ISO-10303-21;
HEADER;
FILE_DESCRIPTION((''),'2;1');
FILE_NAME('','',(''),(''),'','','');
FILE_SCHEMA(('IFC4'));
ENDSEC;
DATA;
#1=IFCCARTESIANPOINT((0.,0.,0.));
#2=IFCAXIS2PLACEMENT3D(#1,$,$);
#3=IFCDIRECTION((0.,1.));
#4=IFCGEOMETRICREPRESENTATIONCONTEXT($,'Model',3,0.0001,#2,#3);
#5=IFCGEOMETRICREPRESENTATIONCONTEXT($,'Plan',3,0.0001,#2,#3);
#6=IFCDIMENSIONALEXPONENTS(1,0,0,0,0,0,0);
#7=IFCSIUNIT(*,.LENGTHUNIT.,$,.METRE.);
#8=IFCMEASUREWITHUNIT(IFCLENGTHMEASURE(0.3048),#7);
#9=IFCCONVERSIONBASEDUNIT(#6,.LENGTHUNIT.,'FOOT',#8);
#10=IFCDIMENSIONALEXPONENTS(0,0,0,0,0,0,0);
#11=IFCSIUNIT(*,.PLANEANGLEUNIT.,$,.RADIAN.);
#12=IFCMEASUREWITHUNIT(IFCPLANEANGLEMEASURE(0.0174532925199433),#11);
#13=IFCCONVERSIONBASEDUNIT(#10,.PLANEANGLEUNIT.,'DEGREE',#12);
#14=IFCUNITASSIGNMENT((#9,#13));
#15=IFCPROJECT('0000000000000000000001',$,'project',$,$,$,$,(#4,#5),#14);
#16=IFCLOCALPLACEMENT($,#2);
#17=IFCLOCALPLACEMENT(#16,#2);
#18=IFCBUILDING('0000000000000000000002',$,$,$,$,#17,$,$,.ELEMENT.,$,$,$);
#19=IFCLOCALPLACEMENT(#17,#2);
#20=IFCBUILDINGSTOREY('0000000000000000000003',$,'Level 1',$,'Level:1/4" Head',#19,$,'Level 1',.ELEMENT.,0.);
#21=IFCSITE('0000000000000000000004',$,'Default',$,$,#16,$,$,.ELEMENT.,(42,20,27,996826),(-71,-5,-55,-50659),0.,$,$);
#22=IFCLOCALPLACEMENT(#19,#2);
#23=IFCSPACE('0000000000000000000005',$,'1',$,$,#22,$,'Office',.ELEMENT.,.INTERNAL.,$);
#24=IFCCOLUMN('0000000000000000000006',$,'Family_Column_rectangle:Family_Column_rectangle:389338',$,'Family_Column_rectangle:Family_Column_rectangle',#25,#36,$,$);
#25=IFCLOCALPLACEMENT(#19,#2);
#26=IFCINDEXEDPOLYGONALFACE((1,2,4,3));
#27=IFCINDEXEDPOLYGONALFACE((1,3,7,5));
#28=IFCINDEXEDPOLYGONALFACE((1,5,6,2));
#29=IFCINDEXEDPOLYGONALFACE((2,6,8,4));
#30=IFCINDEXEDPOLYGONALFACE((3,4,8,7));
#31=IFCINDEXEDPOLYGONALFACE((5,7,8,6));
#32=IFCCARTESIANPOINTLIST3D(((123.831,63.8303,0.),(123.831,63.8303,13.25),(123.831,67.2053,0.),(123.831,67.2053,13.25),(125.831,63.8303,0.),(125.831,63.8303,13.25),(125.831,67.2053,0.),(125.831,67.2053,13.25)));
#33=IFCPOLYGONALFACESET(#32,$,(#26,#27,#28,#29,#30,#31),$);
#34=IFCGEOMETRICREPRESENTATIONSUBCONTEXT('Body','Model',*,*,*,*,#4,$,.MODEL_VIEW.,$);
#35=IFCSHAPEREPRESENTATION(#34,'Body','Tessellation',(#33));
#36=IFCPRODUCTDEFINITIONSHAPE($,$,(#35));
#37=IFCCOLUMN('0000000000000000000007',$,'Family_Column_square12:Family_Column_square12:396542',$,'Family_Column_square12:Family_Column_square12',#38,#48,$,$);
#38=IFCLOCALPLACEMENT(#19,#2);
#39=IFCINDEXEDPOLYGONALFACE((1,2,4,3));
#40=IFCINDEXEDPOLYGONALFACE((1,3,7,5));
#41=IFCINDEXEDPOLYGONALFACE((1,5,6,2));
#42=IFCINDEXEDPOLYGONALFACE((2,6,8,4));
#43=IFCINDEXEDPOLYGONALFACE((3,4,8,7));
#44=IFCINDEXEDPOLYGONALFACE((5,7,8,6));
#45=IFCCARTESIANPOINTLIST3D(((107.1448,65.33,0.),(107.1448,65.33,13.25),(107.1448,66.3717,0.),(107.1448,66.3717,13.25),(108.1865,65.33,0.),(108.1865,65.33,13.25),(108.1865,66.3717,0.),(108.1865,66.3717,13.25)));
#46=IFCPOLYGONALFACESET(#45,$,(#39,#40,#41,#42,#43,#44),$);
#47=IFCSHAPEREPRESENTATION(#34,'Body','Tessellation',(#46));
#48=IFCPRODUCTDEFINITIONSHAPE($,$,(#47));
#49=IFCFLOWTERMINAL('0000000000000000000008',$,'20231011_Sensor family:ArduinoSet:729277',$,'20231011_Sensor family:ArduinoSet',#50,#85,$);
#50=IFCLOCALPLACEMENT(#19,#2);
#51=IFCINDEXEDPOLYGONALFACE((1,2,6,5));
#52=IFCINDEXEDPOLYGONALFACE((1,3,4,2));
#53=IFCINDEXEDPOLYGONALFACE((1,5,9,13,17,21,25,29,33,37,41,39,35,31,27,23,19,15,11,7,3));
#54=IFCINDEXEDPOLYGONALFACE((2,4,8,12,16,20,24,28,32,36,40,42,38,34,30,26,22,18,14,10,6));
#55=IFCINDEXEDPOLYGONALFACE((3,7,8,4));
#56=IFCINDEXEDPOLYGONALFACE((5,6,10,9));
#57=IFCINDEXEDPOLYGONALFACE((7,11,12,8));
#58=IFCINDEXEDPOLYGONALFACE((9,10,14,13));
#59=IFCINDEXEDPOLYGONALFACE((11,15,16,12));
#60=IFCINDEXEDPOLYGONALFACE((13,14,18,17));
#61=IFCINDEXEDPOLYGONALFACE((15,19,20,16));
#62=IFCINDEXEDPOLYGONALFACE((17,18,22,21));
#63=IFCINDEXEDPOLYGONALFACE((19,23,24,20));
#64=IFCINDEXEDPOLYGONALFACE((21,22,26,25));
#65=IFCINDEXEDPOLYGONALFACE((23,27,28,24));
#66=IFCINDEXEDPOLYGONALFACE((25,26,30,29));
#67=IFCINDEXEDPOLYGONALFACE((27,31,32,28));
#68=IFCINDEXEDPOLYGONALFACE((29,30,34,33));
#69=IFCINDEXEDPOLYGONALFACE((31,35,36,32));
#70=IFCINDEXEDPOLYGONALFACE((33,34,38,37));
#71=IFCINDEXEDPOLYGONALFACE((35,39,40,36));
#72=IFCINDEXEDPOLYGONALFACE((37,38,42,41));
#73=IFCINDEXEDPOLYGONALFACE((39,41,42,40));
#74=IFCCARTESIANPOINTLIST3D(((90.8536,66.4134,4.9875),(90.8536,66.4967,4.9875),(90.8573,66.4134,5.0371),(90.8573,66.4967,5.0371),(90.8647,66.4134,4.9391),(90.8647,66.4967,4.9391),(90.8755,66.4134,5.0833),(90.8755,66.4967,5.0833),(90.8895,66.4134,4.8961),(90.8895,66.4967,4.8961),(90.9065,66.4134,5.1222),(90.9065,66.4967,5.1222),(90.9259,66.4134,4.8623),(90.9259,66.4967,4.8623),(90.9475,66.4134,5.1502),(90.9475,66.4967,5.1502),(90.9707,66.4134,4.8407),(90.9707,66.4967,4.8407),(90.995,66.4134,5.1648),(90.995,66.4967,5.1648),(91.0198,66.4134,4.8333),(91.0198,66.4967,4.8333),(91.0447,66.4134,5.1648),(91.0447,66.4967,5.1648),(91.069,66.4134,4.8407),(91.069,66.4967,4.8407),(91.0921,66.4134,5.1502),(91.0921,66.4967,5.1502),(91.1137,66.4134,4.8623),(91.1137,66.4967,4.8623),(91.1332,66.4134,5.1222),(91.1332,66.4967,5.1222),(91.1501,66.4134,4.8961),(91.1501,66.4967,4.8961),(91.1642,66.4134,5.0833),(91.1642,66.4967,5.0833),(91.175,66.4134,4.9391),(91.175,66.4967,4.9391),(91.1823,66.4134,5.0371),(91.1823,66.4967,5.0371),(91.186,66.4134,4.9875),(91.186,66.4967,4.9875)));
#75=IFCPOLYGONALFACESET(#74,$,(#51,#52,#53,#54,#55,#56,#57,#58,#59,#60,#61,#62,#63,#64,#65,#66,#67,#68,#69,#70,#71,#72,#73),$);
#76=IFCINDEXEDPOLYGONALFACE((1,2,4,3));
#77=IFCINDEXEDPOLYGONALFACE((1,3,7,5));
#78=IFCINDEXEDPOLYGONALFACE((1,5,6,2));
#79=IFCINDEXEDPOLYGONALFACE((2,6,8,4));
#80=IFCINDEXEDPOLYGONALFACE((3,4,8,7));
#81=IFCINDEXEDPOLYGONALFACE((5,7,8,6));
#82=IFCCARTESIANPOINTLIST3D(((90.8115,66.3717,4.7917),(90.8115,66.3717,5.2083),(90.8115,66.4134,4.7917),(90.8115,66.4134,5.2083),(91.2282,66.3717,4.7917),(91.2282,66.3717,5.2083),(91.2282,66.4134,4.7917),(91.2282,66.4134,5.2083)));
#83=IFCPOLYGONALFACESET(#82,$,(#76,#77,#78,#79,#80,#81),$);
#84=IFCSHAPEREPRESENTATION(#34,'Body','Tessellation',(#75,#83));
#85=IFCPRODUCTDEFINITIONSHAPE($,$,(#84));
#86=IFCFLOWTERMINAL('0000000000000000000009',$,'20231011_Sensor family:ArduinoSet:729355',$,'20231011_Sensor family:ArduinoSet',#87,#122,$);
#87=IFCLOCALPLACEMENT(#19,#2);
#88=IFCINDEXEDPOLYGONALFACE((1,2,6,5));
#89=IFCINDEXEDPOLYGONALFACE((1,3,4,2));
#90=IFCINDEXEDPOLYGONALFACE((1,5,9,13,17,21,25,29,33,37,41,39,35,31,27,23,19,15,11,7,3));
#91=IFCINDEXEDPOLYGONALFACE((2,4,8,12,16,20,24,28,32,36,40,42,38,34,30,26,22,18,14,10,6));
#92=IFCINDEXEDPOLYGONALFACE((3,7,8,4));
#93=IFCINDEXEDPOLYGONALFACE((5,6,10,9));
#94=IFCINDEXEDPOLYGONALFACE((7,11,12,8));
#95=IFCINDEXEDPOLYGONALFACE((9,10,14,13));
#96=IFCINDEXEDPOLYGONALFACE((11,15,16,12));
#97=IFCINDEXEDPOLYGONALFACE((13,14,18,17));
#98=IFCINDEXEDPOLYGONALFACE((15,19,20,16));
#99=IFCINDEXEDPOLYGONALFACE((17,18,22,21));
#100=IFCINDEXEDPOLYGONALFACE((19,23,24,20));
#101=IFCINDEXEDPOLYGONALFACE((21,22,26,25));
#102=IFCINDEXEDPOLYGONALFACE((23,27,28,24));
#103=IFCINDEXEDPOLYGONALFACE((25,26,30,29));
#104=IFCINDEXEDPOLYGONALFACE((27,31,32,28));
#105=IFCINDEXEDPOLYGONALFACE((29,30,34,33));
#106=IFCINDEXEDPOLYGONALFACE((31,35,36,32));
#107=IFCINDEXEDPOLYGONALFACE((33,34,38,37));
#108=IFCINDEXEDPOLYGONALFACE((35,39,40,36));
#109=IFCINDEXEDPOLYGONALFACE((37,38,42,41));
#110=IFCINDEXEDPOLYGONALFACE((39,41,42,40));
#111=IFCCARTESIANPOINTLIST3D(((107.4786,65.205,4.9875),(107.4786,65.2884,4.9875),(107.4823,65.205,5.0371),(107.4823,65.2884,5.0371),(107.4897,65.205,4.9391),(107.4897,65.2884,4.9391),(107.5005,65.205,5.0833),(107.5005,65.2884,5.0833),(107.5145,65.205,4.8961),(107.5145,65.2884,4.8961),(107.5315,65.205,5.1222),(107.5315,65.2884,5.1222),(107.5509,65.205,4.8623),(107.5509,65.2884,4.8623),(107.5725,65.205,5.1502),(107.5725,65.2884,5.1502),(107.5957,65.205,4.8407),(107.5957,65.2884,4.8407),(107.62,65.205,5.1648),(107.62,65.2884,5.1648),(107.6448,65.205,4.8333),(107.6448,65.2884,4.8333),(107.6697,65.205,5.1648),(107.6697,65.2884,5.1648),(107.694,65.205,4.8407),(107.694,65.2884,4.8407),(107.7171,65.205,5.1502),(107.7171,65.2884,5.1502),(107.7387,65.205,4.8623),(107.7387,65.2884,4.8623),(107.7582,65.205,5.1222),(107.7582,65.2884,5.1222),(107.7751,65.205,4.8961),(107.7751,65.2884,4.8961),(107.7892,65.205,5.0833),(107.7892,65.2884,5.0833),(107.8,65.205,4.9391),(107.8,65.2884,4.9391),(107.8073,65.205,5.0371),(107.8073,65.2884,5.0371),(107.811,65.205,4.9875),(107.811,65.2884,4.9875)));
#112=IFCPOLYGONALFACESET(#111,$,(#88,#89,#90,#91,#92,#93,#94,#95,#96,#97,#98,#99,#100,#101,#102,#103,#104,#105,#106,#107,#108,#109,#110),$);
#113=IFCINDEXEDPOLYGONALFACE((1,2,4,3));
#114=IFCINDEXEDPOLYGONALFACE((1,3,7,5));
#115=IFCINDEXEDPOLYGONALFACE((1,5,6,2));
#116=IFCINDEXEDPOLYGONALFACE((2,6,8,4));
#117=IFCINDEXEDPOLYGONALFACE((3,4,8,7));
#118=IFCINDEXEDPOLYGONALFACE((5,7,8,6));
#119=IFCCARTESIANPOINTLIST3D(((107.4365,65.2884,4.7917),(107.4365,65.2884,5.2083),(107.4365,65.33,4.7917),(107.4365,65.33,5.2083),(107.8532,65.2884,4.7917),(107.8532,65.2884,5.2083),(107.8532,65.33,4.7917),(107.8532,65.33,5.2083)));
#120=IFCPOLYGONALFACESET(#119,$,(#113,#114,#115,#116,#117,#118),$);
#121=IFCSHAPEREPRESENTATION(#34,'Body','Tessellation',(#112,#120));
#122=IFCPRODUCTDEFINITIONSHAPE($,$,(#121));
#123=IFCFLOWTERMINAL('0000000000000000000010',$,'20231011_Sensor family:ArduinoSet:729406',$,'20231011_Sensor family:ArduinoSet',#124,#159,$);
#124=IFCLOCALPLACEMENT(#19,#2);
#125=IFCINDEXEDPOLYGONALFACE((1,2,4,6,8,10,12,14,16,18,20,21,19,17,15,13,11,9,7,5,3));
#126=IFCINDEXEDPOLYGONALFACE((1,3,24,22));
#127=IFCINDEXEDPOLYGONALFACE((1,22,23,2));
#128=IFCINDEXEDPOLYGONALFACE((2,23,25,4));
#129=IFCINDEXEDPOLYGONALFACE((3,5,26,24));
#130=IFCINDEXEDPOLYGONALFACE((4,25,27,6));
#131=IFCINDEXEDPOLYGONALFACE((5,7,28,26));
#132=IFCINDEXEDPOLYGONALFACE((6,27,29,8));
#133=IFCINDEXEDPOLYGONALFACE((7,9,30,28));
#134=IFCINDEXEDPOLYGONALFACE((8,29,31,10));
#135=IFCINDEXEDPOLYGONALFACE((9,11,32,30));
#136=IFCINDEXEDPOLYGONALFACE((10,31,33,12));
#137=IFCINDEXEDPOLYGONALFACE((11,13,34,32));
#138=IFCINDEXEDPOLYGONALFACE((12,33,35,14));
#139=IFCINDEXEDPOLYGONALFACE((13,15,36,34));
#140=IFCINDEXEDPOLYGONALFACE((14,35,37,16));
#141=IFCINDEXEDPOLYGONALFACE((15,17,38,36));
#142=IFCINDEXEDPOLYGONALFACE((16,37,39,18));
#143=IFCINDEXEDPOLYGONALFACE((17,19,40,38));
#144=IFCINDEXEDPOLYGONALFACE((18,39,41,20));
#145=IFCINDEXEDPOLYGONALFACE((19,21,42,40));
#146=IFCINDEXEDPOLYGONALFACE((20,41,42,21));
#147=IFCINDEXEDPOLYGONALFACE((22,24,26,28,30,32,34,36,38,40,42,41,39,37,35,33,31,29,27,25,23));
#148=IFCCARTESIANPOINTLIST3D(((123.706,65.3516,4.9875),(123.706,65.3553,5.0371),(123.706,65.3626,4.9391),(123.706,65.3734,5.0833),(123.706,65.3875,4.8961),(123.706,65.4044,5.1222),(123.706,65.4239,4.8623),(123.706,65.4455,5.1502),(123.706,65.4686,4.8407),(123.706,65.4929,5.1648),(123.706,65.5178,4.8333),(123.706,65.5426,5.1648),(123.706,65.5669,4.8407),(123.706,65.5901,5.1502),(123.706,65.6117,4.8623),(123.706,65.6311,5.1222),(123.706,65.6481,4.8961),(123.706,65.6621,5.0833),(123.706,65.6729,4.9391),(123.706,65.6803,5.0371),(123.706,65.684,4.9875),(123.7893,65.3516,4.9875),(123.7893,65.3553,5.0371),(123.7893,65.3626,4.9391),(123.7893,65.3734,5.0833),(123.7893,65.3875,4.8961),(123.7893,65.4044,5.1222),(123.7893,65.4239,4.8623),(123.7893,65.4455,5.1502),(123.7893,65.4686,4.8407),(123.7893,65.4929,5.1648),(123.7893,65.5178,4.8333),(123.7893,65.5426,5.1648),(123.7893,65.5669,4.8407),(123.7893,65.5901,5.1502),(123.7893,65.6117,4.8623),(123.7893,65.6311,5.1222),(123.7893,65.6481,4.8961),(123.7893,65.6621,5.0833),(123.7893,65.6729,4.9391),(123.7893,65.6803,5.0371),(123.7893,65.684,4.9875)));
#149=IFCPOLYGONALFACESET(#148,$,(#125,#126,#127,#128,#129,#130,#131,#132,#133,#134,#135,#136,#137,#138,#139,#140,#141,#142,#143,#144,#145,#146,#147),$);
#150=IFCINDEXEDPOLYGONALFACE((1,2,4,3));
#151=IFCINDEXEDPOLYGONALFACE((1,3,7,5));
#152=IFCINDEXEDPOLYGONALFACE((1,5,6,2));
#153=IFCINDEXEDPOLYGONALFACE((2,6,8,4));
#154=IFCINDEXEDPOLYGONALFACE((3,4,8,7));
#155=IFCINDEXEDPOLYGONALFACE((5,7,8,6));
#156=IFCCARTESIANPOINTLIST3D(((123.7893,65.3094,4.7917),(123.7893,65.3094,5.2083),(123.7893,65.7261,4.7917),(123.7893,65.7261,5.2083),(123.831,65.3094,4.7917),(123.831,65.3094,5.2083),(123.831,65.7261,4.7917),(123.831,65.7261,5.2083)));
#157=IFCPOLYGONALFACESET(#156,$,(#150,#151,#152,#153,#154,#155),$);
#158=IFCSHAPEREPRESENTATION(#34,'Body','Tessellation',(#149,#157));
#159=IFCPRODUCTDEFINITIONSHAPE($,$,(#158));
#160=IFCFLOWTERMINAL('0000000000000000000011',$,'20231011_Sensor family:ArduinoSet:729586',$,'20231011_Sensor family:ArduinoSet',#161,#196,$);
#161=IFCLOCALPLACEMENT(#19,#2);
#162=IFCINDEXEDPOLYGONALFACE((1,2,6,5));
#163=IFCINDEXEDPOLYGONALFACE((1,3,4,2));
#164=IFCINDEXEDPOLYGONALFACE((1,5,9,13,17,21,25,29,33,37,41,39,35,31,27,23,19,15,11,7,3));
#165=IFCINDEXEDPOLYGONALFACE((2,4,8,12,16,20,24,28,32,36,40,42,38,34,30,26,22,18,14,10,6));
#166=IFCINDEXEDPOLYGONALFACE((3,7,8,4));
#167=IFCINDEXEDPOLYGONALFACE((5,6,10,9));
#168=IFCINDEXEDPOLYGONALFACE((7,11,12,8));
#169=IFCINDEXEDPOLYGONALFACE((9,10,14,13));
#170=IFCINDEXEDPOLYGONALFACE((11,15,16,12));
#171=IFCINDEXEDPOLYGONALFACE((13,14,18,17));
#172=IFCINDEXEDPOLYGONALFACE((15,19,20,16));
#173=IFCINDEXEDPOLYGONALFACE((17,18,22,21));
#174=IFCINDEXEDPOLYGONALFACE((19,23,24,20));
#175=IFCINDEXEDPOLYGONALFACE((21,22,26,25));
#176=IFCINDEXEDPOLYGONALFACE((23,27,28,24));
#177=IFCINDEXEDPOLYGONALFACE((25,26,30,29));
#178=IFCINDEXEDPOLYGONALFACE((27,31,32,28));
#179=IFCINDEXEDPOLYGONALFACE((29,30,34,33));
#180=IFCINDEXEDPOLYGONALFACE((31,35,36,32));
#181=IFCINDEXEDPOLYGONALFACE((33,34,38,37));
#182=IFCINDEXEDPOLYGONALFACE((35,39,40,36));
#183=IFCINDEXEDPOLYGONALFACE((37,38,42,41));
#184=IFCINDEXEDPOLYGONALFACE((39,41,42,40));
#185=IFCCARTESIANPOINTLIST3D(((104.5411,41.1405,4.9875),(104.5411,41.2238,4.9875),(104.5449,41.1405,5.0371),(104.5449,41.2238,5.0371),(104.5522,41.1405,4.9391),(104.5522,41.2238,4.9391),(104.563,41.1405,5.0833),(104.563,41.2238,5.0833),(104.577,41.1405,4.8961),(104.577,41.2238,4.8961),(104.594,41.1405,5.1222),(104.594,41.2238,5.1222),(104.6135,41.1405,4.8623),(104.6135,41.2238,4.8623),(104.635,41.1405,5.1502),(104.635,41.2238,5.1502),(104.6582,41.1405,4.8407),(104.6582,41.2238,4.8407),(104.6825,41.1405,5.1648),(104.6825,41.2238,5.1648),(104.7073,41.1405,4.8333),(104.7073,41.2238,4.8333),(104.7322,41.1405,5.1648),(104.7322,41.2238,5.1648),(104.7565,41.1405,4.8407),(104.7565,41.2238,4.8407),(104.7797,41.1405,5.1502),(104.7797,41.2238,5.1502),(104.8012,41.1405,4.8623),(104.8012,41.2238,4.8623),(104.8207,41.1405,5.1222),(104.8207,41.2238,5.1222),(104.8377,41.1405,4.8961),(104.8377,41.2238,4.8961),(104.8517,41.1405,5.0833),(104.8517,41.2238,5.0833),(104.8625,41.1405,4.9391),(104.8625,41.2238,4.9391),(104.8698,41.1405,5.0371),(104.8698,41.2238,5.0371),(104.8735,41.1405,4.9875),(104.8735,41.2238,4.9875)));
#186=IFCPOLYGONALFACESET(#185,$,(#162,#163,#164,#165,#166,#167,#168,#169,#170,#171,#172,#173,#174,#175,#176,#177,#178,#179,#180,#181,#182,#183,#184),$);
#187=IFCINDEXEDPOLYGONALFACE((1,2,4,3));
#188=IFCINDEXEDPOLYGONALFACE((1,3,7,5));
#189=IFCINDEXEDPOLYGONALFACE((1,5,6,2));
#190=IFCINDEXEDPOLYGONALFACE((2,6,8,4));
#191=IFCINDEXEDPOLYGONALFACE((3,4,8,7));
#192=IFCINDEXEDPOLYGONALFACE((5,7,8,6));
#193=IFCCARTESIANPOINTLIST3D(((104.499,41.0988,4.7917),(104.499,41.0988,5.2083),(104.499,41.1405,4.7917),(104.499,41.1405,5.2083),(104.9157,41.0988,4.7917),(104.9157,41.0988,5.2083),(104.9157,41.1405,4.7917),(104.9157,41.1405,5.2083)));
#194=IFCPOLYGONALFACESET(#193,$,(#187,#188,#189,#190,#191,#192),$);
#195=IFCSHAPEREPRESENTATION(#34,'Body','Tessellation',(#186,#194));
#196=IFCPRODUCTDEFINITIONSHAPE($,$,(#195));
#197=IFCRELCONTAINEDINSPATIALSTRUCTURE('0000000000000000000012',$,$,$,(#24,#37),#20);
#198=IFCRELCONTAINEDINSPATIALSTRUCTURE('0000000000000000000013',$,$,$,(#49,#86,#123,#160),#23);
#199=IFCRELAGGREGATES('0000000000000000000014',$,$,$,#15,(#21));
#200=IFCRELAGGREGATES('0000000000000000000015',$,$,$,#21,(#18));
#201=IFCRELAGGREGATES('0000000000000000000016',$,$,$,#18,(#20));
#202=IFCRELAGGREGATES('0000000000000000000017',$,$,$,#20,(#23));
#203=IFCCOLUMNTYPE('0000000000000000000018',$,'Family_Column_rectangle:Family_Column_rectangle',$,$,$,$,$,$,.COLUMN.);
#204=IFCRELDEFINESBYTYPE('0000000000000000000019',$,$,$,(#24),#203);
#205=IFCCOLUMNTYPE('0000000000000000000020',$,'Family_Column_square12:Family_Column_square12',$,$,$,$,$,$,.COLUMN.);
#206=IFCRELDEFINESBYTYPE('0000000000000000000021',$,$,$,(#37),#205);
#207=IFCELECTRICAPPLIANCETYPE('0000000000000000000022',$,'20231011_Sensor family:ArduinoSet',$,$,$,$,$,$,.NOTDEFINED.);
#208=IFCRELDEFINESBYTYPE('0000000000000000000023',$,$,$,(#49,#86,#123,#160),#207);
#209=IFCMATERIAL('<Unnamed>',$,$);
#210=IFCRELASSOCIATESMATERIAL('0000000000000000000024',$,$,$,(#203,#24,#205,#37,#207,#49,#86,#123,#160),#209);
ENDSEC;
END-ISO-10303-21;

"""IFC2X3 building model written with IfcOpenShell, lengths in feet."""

from ifc_helpers import new_model, entity, si_unit, converted_unit, direction, frame, frame_2d, origin, origin_2d_with_axis, place, context, subcontext, project, spatial, rectangle, circle, extrude, source, transform, mapped, material, type_object, type_shapes, element, save


model = new_model("IFC2X3")

# Units and contexts
model_context = context("Model", 3, precision=0.0001, world=origin(), true_north=direction((0.0, 1.0)))
plan_context = context("Plan", 3, precision=0.0001, world=origin(), true_north=direction((0.0, 1.0)))
body_context = subcontext(model_context, "Body", "Model", "MODEL_VIEW")
ifc_project = project(units=[converted_unit("LENGTHUNIT", "FOOT", entity("IfcLengthMeasure", 0.3048), si_unit("LENGTHUNIT", "METRE"), dimensions=[1, 0, 0, 0, 0, 0, 0]), converted_unit("PLANEANGLEUNIT", "DEGREE", entity("IfcPlaneAngleMeasure", 0.0174532925199433), si_unit("PLANEANGLEUNIT", "RADIAN"), dimensions=[0, 0, 0, 0, 0, 0, 0])], contexts=[model_context, plan_context])

# Site, building, storey
site_placement = place(None, origin())
site = spatial("IfcSite", under=ifc_project, at=site_placement, Name="Default", CompositionType="ELEMENT", RefLatitude=(42, 20, 27, 996826), RefLongitude=(-71, -5, -55, -50659), RefElevation=0.0)
building_placement = place(site_placement, origin())
building = spatial("IfcBuilding", under=site, at=building_placement, CompositionType="ELEMENT")
storey_placement = place(building_placement, origin())
storey = spatial("IfcBuildingStorey", under=building, at=storey_placement, Name="Level 1", ObjectType="Level:1/4\" Head", LongName="Level 1", CompositionType="ELEMENT", Elevation=0.0)

# Columns
ifc_material_1 = material(Name="<Unnamed>")
column_type_1 = type_object("IfcColumnType", Name="Family_Column_rectangle:Family_Column_rectangle", PredefinedType="COLUMN", material=ifc_material_1)
shared_shape_1 = source(origin(), body_context, "Body", "SweptSolid", [
    extrude(rectangle(XDim=3.375, YDim=2.0, at=frame_2d((0.0, 0.0), x_axis=(1.0, 0.0))), frame((0.0, 0.0, 0.0), z_axis=(0.0, 0.0, 1.0), x_axis=(-1.0, 0.0, 0.0)), (0.0, 0.0, 1.0), 13.25),
])
type_shapes(column_type_1, [shared_shape_1])
column_1_placement = place(storey_placement, frame((124.831, 65.5178, 0.0), z_axis=(0.0, 0.0, 1.0), x_axis=(0.0, 1.0, 0.0)))
element("IfcColumn", 1, at=column_1_placement, inside=storey, type_object=column_type_1, material=ifc_material_1, Name="Family_Column_rectangle:Family_Column_rectangle:389338", ObjectType="Family_Column_rectangle:Family_Column_rectangle", context=body_context, shape_type="MappedRepresentation", body=[
    mapped(shared_shape_1, transform((0.0, 0.0, 0.0), scale=1.0)),
])
column_type_2 = type_object("IfcColumnType", Name="Family_Column_square12:Family_Column_square12", PredefinedType="COLUMN", material=ifc_material_1)
shared_shape_2 = source(origin(), body_context, "Body", "SweptSolid", [
    extrude(rectangle(XDim=1.0417, YDim=1.0417, at=frame_2d((0.0, 0.0), x_axis=(1.0, 0.0))), frame((0.0, 0.0, 0.0), z_axis=(0.0, 0.0, 1.0), x_axis=(-1.0, 0.0, 0.0)), (0.0, 0.0, 1.0), 13.25),
])
type_shapes(column_type_2, [shared_shape_2])
column_2_placement = place(storey_placement, frame((107.6657, 65.8509, 0.0)))
element("IfcColumn", 2, at=column_2_placement, inside=storey, type_object=column_type_2, material=ifc_material_1, Name="Family_Column_square12:Family_Column_square12:396542", ObjectType="Family_Column_square12:Family_Column_square12", context=body_context, shape_type="MappedRepresentation", body=[
    mapped(shared_shape_2, transform((0.0, 0.0, 0.0), scale=1.0)),
])

# Shared definitions
space_placement = place(storey_placement, origin())
space = spatial("IfcSpace", under=storey, at=space_placement, Name="1", LongName="Office", CompositionType="ELEMENT", InteriorOrExteriorSpace="INTERNAL")

# Flow terminals
electric_appliance_type = type_object("IfcElectricApplianceType", Name="20231011_Sensor family:ArduinoSet", PredefinedType="NOTDEFINED", material=ifc_material_1)
shared_shape_3 = source(origin(), body_context, "Body", "SweptSolid", [
    extrude(circle(Radius=0.1667, at=frame_2d((0.0, 0.0), x_axis=(1.0, 0.0))), frame((0.0417, 0.0, 0.0), z_axis=(1.0, 0.0, 0.0), x_axis=(0.0, 0.0, -1.0)), (0.0, 0.0, 1.0), 0.0833),
    extrude(rectangle(XDim=0.0417, YDim=0.4167, at=origin_2d_with_axis()), frame((0.0208, 0.0, -0.2083), z_axis=(0.0, 0.0, 1.0), x_axis=(-1.0, 0.0, 0.0)), (0.0, 0.0, 1.0), 0.4167),
])
type_shapes(electric_appliance_type, [shared_shape_3])
for number, where, z_axis, x_axis, name in (
    (3, (91.0198, 66.3717, 5.0), (0.0, 0.0, 1.0), (0.0, 1.0, 0.0), "20231011_Sensor family:ArduinoSet:729277"),
    (4, (107.6448, 65.33, 5.0), (0.0, 0.0, 1.0), (0.0, -1.0, 0.0), "20231011_Sensor family:ArduinoSet:729355"),
    (5, (123.831, 65.5178, 5.0), (0.0, 0.0, 1.0), (-1.0, 0.0, 0.0), "20231011_Sensor family:ArduinoSet:729406"),
    (6, (104.7073, 41.0988, 5.0), (0.0, 0.0, 1.0), (0.0, 1.0, 0.0), "20231011_Sensor family:ArduinoSet:729586"),
):
    element("IfcFlowTerminal", number, at=place(space_placement, frame(where, z_axis=z_axis, x_axis=x_axis)), inside=space, type_object=electric_appliance_type, material=ifc_material_1, Name=name, ObjectType="20231011_Sensor family:ArduinoSet", context=body_context, shape_type="MappedRepresentation", body=[
        mapped(shared_shape_3, transform((0.0, 0.0, 0.0), scale=1.0)),
    ])

save(model, "model.ifc")
